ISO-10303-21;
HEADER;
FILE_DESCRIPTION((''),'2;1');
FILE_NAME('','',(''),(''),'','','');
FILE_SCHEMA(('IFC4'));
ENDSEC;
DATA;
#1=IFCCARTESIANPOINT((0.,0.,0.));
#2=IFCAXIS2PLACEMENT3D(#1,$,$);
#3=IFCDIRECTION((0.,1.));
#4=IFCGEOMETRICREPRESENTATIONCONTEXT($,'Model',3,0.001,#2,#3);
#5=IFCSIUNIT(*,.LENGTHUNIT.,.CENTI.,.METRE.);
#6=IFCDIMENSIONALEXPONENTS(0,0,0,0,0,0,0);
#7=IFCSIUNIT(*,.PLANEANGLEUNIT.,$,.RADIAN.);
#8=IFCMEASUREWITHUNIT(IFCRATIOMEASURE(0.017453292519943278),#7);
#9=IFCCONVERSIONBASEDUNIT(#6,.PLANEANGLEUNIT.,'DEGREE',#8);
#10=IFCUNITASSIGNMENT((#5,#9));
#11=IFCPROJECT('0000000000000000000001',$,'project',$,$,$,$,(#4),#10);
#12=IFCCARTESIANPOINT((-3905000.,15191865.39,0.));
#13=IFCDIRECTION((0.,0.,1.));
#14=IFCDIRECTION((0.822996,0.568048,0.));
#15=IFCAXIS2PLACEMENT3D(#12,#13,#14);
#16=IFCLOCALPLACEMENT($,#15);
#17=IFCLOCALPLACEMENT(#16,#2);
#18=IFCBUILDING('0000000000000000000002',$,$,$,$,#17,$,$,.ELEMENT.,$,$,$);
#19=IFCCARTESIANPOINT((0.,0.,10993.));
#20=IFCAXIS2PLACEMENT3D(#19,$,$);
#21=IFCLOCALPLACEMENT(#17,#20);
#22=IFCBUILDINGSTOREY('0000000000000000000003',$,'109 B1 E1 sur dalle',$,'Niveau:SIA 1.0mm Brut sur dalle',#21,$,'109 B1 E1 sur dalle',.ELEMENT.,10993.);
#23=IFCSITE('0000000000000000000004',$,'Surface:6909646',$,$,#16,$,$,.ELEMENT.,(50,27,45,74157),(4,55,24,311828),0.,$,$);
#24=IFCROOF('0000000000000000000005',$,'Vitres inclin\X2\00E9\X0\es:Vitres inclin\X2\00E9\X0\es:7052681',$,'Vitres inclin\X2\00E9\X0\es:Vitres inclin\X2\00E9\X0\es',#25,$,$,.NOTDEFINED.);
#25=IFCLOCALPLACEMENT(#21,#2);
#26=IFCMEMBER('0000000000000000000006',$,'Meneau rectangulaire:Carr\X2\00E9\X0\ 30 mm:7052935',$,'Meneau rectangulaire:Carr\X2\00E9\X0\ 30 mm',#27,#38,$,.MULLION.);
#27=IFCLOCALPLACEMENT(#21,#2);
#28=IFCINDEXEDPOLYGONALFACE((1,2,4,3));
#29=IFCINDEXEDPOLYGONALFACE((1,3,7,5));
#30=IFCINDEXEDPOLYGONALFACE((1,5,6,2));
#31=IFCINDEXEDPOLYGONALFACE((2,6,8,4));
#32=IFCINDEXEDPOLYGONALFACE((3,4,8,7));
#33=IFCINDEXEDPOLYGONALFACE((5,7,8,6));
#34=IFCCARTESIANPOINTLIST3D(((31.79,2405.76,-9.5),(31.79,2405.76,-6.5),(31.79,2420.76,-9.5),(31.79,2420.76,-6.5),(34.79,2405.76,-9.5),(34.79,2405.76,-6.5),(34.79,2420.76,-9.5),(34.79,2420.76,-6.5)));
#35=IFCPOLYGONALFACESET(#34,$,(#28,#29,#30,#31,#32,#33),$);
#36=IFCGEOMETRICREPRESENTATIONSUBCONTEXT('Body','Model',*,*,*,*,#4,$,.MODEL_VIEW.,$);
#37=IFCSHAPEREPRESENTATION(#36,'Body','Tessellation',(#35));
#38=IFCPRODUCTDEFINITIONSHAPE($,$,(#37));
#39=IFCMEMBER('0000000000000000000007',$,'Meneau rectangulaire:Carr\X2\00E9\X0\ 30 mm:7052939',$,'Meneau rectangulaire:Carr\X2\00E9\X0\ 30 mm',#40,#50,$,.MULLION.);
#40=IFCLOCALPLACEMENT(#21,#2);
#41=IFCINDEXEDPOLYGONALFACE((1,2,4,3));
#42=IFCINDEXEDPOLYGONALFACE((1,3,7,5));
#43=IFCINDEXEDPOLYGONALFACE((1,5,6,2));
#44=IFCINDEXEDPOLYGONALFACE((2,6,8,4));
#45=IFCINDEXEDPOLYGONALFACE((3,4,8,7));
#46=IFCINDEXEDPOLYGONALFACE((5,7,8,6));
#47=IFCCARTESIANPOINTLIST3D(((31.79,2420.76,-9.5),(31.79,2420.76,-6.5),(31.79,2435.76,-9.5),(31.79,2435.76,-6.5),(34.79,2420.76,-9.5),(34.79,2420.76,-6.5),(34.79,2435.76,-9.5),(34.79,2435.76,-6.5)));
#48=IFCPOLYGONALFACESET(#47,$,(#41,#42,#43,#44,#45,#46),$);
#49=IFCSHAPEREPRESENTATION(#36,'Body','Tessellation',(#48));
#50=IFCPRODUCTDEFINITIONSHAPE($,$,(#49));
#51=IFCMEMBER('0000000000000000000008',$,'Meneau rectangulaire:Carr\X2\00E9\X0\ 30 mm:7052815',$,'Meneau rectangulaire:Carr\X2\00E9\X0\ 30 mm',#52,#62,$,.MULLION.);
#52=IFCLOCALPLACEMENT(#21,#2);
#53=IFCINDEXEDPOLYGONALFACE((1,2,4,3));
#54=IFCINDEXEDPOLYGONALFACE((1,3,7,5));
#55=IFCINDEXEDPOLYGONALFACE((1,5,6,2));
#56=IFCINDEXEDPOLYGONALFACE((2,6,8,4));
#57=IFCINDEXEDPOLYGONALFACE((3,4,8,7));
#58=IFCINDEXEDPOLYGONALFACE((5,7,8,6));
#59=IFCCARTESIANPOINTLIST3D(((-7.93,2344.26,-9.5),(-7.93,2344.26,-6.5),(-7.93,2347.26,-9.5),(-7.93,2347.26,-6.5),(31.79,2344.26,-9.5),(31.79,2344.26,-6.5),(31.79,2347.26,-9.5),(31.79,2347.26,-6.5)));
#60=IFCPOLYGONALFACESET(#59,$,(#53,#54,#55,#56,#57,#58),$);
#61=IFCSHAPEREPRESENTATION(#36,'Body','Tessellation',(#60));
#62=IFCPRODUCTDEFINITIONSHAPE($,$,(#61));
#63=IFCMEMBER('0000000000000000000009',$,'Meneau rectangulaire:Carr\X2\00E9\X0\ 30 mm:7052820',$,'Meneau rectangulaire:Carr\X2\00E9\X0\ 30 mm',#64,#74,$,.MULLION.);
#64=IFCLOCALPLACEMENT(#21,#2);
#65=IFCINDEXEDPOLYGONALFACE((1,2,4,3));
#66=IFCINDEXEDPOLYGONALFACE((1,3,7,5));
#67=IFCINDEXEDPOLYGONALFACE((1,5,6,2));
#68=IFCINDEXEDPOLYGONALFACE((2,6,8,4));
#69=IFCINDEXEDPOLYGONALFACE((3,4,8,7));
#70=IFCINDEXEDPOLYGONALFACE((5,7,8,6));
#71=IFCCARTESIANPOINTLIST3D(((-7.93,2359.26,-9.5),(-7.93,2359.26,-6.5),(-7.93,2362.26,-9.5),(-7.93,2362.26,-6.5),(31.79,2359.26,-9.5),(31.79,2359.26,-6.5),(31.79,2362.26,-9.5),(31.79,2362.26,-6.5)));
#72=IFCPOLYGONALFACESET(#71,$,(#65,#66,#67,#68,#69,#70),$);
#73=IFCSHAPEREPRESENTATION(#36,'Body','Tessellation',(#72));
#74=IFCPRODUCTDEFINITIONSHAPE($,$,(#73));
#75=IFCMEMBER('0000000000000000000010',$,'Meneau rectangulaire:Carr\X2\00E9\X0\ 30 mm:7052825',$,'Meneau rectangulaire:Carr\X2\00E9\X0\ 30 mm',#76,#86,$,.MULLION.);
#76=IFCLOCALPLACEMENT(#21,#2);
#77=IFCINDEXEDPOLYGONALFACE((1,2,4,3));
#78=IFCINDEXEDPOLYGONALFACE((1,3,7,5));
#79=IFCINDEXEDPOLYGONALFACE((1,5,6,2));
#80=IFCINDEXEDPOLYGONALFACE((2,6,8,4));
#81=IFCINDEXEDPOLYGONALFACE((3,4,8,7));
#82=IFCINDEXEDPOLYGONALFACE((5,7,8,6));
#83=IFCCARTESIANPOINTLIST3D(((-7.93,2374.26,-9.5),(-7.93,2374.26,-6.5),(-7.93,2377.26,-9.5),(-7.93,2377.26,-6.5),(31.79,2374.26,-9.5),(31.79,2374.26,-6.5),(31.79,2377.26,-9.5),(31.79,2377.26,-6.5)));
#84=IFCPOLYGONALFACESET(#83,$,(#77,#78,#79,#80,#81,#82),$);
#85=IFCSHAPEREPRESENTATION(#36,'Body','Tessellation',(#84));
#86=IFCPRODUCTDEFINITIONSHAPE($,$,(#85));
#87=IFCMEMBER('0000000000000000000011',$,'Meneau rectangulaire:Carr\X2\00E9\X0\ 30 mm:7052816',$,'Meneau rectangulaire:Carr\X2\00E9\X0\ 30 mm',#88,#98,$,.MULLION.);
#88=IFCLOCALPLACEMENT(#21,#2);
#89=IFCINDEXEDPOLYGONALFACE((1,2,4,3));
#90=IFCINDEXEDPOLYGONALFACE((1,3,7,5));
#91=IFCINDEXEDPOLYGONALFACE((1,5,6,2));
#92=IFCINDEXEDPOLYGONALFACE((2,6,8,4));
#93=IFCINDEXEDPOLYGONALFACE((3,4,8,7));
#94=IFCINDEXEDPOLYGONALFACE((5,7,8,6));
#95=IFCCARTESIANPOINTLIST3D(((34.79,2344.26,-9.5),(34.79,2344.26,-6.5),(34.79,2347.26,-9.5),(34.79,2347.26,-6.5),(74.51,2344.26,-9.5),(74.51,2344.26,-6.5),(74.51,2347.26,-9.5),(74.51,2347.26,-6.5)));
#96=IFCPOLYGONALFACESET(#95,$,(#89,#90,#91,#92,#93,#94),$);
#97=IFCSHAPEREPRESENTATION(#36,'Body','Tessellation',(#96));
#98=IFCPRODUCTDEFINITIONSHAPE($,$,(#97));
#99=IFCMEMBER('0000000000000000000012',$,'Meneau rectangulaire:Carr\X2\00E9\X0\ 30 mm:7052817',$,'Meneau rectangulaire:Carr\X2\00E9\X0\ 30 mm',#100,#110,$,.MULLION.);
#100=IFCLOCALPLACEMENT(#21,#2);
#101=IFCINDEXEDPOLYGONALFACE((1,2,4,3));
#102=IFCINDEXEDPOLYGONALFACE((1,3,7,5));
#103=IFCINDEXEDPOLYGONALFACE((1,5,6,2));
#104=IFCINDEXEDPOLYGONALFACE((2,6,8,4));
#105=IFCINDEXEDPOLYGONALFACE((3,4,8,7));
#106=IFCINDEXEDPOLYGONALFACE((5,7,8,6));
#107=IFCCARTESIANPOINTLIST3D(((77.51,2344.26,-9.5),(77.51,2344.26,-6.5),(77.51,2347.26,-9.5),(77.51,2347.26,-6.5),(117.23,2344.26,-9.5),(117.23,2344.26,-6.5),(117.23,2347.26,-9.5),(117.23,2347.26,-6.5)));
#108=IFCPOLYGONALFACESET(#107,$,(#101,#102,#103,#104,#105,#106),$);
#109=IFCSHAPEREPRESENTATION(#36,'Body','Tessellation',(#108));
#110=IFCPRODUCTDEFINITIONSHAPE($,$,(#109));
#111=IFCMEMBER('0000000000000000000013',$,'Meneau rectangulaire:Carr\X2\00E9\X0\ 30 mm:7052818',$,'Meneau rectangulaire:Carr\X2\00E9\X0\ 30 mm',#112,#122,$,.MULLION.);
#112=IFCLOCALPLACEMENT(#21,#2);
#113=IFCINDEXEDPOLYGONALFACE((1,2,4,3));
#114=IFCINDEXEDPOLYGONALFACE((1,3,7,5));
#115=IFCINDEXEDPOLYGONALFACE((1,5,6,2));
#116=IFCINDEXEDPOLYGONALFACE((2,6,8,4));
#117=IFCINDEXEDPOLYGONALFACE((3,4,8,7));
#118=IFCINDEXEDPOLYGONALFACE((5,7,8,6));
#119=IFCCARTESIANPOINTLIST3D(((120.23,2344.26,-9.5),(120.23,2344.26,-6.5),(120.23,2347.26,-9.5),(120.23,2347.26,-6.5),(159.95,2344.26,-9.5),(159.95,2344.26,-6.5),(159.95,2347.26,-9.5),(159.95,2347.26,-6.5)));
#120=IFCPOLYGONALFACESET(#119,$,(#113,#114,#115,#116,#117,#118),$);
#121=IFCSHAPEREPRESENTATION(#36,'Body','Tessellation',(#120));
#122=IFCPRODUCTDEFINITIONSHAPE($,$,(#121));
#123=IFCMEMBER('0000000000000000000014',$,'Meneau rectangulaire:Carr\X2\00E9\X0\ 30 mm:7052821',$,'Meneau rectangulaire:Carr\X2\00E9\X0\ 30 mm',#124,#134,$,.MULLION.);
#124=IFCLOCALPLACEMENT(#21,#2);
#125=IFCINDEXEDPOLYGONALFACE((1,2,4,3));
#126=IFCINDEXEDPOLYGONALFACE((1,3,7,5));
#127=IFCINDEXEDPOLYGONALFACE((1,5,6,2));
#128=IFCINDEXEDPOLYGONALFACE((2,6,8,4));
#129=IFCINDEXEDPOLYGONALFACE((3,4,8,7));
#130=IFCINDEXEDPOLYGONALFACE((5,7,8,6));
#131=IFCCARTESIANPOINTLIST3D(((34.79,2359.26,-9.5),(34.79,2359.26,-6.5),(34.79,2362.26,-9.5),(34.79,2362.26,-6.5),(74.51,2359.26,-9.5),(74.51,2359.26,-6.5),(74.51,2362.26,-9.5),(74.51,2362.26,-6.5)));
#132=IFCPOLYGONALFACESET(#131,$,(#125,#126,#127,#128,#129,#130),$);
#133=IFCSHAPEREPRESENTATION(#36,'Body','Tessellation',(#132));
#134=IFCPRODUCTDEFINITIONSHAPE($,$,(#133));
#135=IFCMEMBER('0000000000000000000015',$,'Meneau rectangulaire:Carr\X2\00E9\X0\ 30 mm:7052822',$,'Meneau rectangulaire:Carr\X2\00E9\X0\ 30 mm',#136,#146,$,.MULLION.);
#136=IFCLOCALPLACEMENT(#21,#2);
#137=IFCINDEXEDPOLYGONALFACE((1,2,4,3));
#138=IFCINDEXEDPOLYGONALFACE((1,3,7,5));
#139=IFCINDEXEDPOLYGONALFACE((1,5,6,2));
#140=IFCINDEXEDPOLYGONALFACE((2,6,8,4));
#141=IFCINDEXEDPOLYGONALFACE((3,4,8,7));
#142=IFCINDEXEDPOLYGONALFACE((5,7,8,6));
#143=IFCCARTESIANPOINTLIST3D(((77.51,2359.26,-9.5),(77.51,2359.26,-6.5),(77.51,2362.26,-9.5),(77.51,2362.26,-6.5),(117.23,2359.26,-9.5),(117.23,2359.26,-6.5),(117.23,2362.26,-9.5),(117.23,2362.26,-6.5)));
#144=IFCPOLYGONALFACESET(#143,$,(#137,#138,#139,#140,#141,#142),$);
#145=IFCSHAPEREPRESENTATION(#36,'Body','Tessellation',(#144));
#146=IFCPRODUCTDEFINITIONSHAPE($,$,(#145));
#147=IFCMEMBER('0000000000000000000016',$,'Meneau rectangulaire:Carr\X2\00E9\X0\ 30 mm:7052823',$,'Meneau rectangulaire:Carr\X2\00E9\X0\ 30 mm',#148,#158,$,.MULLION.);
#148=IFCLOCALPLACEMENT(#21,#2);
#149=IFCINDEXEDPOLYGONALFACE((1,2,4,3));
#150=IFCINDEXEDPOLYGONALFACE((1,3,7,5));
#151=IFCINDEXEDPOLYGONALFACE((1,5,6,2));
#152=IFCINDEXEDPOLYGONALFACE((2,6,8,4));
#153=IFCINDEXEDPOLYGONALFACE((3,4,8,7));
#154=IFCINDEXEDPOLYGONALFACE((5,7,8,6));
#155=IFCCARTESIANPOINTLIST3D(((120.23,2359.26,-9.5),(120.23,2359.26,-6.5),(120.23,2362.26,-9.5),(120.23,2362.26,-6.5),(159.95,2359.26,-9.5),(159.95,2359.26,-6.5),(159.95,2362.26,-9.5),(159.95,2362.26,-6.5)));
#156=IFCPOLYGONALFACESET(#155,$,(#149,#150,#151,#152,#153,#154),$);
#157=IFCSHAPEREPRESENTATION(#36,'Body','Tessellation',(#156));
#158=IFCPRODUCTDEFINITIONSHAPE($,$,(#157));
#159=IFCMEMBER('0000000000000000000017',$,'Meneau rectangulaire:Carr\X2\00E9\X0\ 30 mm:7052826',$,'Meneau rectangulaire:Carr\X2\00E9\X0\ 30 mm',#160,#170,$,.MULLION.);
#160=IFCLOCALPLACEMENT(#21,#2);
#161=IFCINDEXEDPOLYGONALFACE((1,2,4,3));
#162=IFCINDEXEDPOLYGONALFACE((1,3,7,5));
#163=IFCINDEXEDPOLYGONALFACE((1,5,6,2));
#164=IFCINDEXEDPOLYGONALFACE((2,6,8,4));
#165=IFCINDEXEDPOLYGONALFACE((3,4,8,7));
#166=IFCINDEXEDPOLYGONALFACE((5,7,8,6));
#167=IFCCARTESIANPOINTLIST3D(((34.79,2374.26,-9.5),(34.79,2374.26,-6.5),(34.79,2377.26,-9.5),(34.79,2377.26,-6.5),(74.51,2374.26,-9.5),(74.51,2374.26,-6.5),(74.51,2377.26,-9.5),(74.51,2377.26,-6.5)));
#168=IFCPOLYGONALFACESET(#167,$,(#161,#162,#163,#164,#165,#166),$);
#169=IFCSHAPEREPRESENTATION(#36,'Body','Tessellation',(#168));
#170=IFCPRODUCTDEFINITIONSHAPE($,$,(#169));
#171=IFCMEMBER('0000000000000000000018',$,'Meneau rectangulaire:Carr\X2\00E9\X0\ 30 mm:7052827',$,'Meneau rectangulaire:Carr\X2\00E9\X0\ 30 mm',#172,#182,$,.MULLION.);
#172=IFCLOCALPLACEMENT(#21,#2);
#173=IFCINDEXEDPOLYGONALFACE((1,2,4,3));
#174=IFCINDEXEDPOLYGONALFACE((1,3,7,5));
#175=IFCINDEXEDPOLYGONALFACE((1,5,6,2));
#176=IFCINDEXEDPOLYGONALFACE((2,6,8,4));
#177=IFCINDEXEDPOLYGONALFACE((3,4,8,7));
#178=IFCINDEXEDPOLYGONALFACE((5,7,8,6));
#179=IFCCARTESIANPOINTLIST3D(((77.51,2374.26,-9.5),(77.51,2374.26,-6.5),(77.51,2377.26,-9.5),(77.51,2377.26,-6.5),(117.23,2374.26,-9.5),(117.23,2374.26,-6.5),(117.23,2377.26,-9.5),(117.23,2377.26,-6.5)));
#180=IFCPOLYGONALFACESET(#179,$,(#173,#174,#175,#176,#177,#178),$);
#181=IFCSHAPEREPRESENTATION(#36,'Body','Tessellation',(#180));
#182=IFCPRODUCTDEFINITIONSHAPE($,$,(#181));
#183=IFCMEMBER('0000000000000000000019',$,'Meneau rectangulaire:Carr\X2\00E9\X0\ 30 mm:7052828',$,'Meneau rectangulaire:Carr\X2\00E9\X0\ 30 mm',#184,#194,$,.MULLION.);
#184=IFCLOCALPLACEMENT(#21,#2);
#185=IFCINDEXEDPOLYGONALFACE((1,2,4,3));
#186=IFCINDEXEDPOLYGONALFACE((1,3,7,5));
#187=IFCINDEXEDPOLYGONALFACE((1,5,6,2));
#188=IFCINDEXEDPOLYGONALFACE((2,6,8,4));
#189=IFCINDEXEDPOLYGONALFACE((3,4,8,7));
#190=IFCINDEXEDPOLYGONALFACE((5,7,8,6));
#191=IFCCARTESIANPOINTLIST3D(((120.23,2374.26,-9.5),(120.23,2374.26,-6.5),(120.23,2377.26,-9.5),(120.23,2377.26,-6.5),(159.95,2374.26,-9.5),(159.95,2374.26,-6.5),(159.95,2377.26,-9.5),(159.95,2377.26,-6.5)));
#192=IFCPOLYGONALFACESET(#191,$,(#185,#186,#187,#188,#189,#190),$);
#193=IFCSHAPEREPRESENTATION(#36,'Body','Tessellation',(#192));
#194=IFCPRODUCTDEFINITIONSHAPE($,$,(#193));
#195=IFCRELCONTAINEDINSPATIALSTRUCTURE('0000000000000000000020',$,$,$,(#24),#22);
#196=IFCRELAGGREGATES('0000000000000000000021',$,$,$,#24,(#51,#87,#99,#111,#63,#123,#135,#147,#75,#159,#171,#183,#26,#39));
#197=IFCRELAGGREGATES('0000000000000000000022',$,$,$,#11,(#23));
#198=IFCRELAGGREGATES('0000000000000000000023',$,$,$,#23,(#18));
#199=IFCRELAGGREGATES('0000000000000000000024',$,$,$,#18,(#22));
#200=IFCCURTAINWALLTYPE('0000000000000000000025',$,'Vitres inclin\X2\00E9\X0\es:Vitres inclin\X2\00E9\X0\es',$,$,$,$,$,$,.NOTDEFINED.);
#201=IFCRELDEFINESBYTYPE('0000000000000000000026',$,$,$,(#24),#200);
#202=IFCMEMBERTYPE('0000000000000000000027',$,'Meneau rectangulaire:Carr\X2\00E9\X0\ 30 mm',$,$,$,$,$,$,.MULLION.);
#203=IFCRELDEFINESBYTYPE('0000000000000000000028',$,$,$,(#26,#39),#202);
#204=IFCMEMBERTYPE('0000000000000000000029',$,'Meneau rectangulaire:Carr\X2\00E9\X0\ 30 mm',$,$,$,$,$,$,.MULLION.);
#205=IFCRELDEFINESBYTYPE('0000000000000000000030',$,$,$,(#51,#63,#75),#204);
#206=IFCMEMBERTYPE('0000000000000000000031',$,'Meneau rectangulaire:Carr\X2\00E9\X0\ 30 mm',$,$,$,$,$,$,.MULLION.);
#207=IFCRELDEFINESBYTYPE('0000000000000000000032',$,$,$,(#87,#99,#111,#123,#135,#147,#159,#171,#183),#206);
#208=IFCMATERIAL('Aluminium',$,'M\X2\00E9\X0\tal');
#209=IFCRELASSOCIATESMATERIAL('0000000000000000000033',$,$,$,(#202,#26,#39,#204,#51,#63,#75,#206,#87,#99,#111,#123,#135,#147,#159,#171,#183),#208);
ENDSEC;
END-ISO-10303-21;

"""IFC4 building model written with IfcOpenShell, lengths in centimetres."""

from ifc_helpers import new_model, entity, si_unit, converted_unit, direction, frame, origin, place, context, subcontext, project, spatial, indexed_curve, outline, extrude, source, transform, mapped, material, type_object, type_shapes, element, aggregate, save


model = new_model("IFC4")

# Units and contexts
model_context = context("Model", 3, precision=0.001, world=origin(), true_north=direction((0.0, 1.0)))
body_context = subcontext(model_context, "Body", "Model", "MODEL_VIEW")
ifc_project = project(units=[si_unit("LENGTHUNIT", "METRE", prefix="CENTI"), converted_unit("PLANEANGLEUNIT", "DEGREE", entity("IfcRatioMeasure", 0.017453292519943278), si_unit("PLANEANGLEUNIT", "RADIAN"), dimensions=[0, 0, 0, 0, 0, 0, 0])], contexts=[model_context])

# Site, building, storey
site_placement = place(None, frame((-3905000.0, 15191865.39, 0.0), z_axis=(0.0, 0.0, 1.0), x_axis=(0.822996, 0.568048, 0.0)))
site = spatial("IfcSite", under=ifc_project, at=site_placement, Name="Surface:6909646", CompositionType="ELEMENT", RefLatitude=(50, 27, 45, 74157), RefLongitude=(4, 55, 24, 311828), RefElevation=0.0)
building_placement = place(site_placement, origin())
building = spatial("IfcBuilding", under=site, at=building_placement, CompositionType="ELEMENT")
storey_placement = place(building_placement, frame((0.0, 0.0, 10993.0)))
storey = spatial("IfcBuildingStorey", under=building, at=storey_placement, Name="109 B1 E1 sur dalle", ObjectType="Niveau:SIA 1.0mm Brut sur dalle", LongName="109 B1 E1 sur dalle", CompositionType="ELEMENT", Elevation=10993.0)

# Roof, members
curtain_wall_type = type_object("IfcCurtainWallType", Name="Vitres inclinées:Vitres inclinées", PredefinedType="NOTDEFINED")
roof_placement = place(storey_placement, frame((0.0, 0.0, -10993.0)))
roof = element("IfcRoof", 1, at=roof_placement, inside=storey, type_object=curtain_wall_type, Name="Vitres inclinées:Vitres inclinées:7052681", ObjectType="Vitres inclinées:Vitres inclinées", PredefinedType="NOTDEFINED")
ifc_material = material(Name="Aluminium", Category="Métal")
member_type_1 = type_object("IfcMemberType", Name="Meneau rectangulaire:Carré 30 mm", PredefinedType="MULLION", material=ifc_material)
shared_shape_1 = source(origin(), body_context, "Body", "SweptSolid", [
    extrude(outline(indexed_curve([(-1.5, -1.5), (1.5, -1.5), (1.5, 1.5), (-1.5, 1.5), (-1.5, -1.5)], self_intersect=False)), frame((0.0, 0.0, -15.0), z_axis=(0.0, 0.0, 1.0), x_axis=(0.0, -1.0, 0.0)), (0.0, 0.0, 1.0), 15.0),
])
type_shapes(member_type_1, [shared_shape_1])
member_1_placement = place(roof_placement, frame((33.29, 2420.76, 10985.0), z_axis=(0.0, 1.0, 0.0), x_axis=(1.0, 0.0, 0.0)))
member_1 = element("IfcMember", 2, at=member_1_placement, type_object=member_type_1, material=ifc_material, Name="Meneau rectangulaire:Carré 30 mm:7052935", ObjectType="Meneau rectangulaire:Carré 30 mm", PredefinedType="MULLION", context=body_context, shape_type="MappedRepresentation", body=[
    mapped(shared_shape_1, transform((0.0, 0.0, 0.0), scale=1.0)),
])
member_2_placement = place(roof_placement, frame((33.29, 2435.76, 10985.0), z_axis=(0.0, 1.0, 0.0), x_axis=(1.0, 0.0, 0.0)))
member_2 = element("IfcMember", 3, at=member_2_placement, type_object=member_type_1, material=ifc_material, Name="Meneau rectangulaire:Carré 30 mm:7052939", ObjectType="Meneau rectangulaire:Carré 30 mm", PredefinedType="MULLION", context=body_context, shape_type="MappedRepresentation", body=[
    mapped(shared_shape_1, transform((0.0, 0.0, 0.0), scale=1.0)),
])
member_type_2 = type_object("IfcMemberType", Name="Meneau rectangulaire:Carré 30 mm", PredefinedType="MULLION", material=ifc_material)
shared_shape_2 = source(origin(), body_context, "Body", "SweptSolid", [
    extrude(outline(indexed_curve([(-1.5, -1.5), (1.5, -1.5), (1.5, 1.5), (-1.5, 1.5), (-1.5, -1.5)], self_intersect=False)), frame((0.0, 0.0, -39.72), z_axis=(0.0, 0.0, 1.0), x_axis=(0.0, -1.0, 0.0)), (0.0, 0.0, 1.0), 39.72),
])
type_shapes(member_type_2, [shared_shape_2])
member_3_placement = place(roof_placement, frame((-7.93, 2345.76, 10985.0), z_axis=(-1.0, 0.0, 0.0), x_axis=(0.0, 1.0, 0.0)))
member_3 = element("IfcMember", 4, at=member_3_placement, type_object=member_type_2, material=ifc_material, Name="Meneau rectangulaire:Carré 30 mm:7052815", ObjectType="Meneau rectangulaire:Carré 30 mm", PredefinedType="MULLION", context=body_context, shape_type="MappedRepresentation", body=[
    mapped(shared_shape_2, transform((0.0, 0.0, 0.0), scale=1.0)),
])
member_4_placement = place(roof_placement, frame((-7.93, 2360.76, 10985.0), z_axis=(-1.0, 0.0, 0.0), x_axis=(0.0, 1.0, 0.0)))
member_4 = element("IfcMember", 5, at=member_4_placement, type_object=member_type_2, material=ifc_material, Name="Meneau rectangulaire:Carré 30 mm:7052820", ObjectType="Meneau rectangulaire:Carré 30 mm", PredefinedType="MULLION", context=body_context, shape_type="MappedRepresentation", body=[
    mapped(shared_shape_2, transform((0.0, 0.0, 0.0), scale=1.0)),
])
member_5_placement = place(roof_placement, frame((-7.93, 2375.76, 10985.0), z_axis=(-1.0, 0.0, 0.0), x_axis=(0.0, 1.0, 0.0)))
member_5 = element("IfcMember", 6, at=member_5_placement, type_object=member_type_2, material=ifc_material, Name="Meneau rectangulaire:Carré 30 mm:7052825", ObjectType="Meneau rectangulaire:Carré 30 mm", PredefinedType="MULLION", context=body_context, shape_type="MappedRepresentation", body=[
    mapped(shared_shape_2, transform((0.0, 0.0, 0.0), scale=1.0)),
])
member_type_3 = type_object("IfcMemberType", Name="Meneau rectangulaire:Carré 30 mm", PredefinedType="MULLION", material=ifc_material)
shared_shape_3 = source(origin(), body_context, "Body", "SweptSolid", [
    extrude(outline(indexed_curve([(-1.5, -1.5), (1.5, -1.5), (1.5, 1.5), (-1.5, 1.5), (-1.5, -1.5)], self_intersect=False)), frame((0.0, 0.0, -39.72), z_axis=(0.0, 0.0, 1.0), x_axis=(0.0, -1.0, 0.0)), (0.0, 0.0, 1.0), 39.72),
])
type_shapes(member_type_3, [shared_shape_3])
member_6_placement = place(roof_placement, frame((34.79, 2345.76, 10985.0), z_axis=(-1.0, 0.0, 0.0), x_axis=(0.0, 1.0, 0.0)))
member_6 = element("IfcMember", 7, at=member_6_placement, type_object=member_type_3, material=ifc_material, Name="Meneau rectangulaire:Carré 30 mm:7052816", ObjectType="Meneau rectangulaire:Carré 30 mm", PredefinedType="MULLION", context=body_context, shape_type="MappedRepresentation", body=[
    mapped(shared_shape_3, transform((0.0, 0.0, 0.0), scale=1.0)),
])
member_7_placement = place(roof_placement, frame((77.51, 2345.76, 10985.0), z_axis=(-1.0, 0.0, 0.0), x_axis=(0.0, 1.0, 0.0)))
member_7 = element("IfcMember", 8, at=member_7_placement, type_object=member_type_3, material=ifc_material, Name="Meneau rectangulaire:Carré 30 mm:7052817", ObjectType="Meneau rectangulaire:Carré 30 mm", PredefinedType="MULLION", context=body_context, shape_type="MappedRepresentation", body=[
    mapped(shared_shape_3, transform((0.0, 0.0, 0.0), scale=1.0)),
])
member_8_placement = place(roof_placement, frame((120.23, 2345.76, 10985.0), z_axis=(-1.0, 0.0, 0.0), x_axis=(0.0, 1.0, 0.0)))
member_8 = element("IfcMember", 9, at=member_8_placement, type_object=member_type_3, material=ifc_material, Name="Meneau rectangulaire:Carré 30 mm:7052818", ObjectType="Meneau rectangulaire:Carré 30 mm", PredefinedType="MULLION", context=body_context, shape_type="MappedRepresentation", body=[
    mapped(shared_shape_3, transform((0.0, 0.0, 0.0), scale=1.0)),
])
member_9_placement = place(roof_placement, frame((34.79, 2360.76, 10985.0), z_axis=(-1.0, 0.0, 0.0), x_axis=(0.0, 1.0, 0.0)))
member_9 = element("IfcMember", 10, at=member_9_placement, type_object=member_type_3, material=ifc_material, Name="Meneau rectangulaire:Carré 30 mm:7052821", ObjectType="Meneau rectangulaire:Carré 30 mm", PredefinedType="MULLION", context=body_context, shape_type="MappedRepresentation", body=[
    mapped(shared_shape_3, transform((0.0, 0.0, 0.0), scale=1.0)),
])
member_10_placement = place(roof_placement, frame((77.51, 2360.76, 10985.0), z_axis=(-1.0, 0.0, 0.0), x_axis=(0.0, 1.0, 0.0)))
member_10 = element("IfcMember", 11, at=member_10_placement, type_object=member_type_3, material=ifc_material, Name="Meneau rectangulaire:Carré 30 mm:7052822", ObjectType="Meneau rectangulaire:Carré 30 mm", PredefinedType="MULLION", context=body_context, shape_type="MappedRepresentation", body=[
    mapped(shared_shape_3, transform((0.0, 0.0, 0.0), scale=1.0)),
])
member_11_placement = place(roof_placement, frame((120.23, 2360.76, 10985.0), z_axis=(-1.0, 0.0, 0.0), x_axis=(0.0, 1.0, 0.0)))
member_11 = element("IfcMember", 12, at=member_11_placement, type_object=member_type_3, material=ifc_material, Name="Meneau rectangulaire:Carré 30 mm:7052823", ObjectType="Meneau rectangulaire:Carré 30 mm", PredefinedType="MULLION", context=body_context, shape_type="MappedRepresentation", body=[
    mapped(shared_shape_3, transform((0.0, 0.0, 0.0), scale=1.0)),
])
member_12_placement = place(roof_placement, frame((34.79, 2375.76, 10985.0), z_axis=(-1.0, 0.0, 0.0), x_axis=(0.0, 1.0, 0.0)))
member_12 = element("IfcMember", 13, at=member_12_placement, type_object=member_type_3, material=ifc_material, Name="Meneau rectangulaire:Carré 30 mm:7052826", ObjectType="Meneau rectangulaire:Carré 30 mm", PredefinedType="MULLION", context=body_context, shape_type="MappedRepresentation", body=[
    mapped(shared_shape_3, transform((0.0, 0.0, 0.0), scale=1.0)),
])
member_13_placement = place(roof_placement, frame((77.51, 2375.76, 10985.0), z_axis=(-1.0, 0.0, 0.0), x_axis=(0.0, 1.0, 0.0)))
member_13 = element("IfcMember", 14, at=member_13_placement, type_object=member_type_3, material=ifc_material, Name="Meneau rectangulaire:Carré 30 mm:7052827", ObjectType="Meneau rectangulaire:Carré 30 mm", PredefinedType="MULLION", context=body_context, shape_type="MappedRepresentation", body=[
    mapped(shared_shape_3, transform((0.0, 0.0, 0.0), scale=1.0)),
])
member_14_placement = place(roof_placement, frame((120.23, 2375.76, 10985.0), z_axis=(-1.0, 0.0, 0.0), x_axis=(0.0, 1.0, 0.0)))
member_14 = element("IfcMember", 15, at=member_14_placement, type_object=member_type_3, material=ifc_material, Name="Meneau rectangulaire:Carré 30 mm:7052828", ObjectType="Meneau rectangulaire:Carré 30 mm", PredefinedType="MULLION", context=body_context, shape_type="MappedRepresentation", body=[
    mapped(shared_shape_3, transform((0.0, 0.0, 0.0), scale=1.0)),
])
aggregate(roof, [member_3, member_6, member_7, member_8, member_4, member_9, member_10, member_11, member_5, member_12, member_13, member_14, member_1, member_2])

save(model, "model.ifc")
